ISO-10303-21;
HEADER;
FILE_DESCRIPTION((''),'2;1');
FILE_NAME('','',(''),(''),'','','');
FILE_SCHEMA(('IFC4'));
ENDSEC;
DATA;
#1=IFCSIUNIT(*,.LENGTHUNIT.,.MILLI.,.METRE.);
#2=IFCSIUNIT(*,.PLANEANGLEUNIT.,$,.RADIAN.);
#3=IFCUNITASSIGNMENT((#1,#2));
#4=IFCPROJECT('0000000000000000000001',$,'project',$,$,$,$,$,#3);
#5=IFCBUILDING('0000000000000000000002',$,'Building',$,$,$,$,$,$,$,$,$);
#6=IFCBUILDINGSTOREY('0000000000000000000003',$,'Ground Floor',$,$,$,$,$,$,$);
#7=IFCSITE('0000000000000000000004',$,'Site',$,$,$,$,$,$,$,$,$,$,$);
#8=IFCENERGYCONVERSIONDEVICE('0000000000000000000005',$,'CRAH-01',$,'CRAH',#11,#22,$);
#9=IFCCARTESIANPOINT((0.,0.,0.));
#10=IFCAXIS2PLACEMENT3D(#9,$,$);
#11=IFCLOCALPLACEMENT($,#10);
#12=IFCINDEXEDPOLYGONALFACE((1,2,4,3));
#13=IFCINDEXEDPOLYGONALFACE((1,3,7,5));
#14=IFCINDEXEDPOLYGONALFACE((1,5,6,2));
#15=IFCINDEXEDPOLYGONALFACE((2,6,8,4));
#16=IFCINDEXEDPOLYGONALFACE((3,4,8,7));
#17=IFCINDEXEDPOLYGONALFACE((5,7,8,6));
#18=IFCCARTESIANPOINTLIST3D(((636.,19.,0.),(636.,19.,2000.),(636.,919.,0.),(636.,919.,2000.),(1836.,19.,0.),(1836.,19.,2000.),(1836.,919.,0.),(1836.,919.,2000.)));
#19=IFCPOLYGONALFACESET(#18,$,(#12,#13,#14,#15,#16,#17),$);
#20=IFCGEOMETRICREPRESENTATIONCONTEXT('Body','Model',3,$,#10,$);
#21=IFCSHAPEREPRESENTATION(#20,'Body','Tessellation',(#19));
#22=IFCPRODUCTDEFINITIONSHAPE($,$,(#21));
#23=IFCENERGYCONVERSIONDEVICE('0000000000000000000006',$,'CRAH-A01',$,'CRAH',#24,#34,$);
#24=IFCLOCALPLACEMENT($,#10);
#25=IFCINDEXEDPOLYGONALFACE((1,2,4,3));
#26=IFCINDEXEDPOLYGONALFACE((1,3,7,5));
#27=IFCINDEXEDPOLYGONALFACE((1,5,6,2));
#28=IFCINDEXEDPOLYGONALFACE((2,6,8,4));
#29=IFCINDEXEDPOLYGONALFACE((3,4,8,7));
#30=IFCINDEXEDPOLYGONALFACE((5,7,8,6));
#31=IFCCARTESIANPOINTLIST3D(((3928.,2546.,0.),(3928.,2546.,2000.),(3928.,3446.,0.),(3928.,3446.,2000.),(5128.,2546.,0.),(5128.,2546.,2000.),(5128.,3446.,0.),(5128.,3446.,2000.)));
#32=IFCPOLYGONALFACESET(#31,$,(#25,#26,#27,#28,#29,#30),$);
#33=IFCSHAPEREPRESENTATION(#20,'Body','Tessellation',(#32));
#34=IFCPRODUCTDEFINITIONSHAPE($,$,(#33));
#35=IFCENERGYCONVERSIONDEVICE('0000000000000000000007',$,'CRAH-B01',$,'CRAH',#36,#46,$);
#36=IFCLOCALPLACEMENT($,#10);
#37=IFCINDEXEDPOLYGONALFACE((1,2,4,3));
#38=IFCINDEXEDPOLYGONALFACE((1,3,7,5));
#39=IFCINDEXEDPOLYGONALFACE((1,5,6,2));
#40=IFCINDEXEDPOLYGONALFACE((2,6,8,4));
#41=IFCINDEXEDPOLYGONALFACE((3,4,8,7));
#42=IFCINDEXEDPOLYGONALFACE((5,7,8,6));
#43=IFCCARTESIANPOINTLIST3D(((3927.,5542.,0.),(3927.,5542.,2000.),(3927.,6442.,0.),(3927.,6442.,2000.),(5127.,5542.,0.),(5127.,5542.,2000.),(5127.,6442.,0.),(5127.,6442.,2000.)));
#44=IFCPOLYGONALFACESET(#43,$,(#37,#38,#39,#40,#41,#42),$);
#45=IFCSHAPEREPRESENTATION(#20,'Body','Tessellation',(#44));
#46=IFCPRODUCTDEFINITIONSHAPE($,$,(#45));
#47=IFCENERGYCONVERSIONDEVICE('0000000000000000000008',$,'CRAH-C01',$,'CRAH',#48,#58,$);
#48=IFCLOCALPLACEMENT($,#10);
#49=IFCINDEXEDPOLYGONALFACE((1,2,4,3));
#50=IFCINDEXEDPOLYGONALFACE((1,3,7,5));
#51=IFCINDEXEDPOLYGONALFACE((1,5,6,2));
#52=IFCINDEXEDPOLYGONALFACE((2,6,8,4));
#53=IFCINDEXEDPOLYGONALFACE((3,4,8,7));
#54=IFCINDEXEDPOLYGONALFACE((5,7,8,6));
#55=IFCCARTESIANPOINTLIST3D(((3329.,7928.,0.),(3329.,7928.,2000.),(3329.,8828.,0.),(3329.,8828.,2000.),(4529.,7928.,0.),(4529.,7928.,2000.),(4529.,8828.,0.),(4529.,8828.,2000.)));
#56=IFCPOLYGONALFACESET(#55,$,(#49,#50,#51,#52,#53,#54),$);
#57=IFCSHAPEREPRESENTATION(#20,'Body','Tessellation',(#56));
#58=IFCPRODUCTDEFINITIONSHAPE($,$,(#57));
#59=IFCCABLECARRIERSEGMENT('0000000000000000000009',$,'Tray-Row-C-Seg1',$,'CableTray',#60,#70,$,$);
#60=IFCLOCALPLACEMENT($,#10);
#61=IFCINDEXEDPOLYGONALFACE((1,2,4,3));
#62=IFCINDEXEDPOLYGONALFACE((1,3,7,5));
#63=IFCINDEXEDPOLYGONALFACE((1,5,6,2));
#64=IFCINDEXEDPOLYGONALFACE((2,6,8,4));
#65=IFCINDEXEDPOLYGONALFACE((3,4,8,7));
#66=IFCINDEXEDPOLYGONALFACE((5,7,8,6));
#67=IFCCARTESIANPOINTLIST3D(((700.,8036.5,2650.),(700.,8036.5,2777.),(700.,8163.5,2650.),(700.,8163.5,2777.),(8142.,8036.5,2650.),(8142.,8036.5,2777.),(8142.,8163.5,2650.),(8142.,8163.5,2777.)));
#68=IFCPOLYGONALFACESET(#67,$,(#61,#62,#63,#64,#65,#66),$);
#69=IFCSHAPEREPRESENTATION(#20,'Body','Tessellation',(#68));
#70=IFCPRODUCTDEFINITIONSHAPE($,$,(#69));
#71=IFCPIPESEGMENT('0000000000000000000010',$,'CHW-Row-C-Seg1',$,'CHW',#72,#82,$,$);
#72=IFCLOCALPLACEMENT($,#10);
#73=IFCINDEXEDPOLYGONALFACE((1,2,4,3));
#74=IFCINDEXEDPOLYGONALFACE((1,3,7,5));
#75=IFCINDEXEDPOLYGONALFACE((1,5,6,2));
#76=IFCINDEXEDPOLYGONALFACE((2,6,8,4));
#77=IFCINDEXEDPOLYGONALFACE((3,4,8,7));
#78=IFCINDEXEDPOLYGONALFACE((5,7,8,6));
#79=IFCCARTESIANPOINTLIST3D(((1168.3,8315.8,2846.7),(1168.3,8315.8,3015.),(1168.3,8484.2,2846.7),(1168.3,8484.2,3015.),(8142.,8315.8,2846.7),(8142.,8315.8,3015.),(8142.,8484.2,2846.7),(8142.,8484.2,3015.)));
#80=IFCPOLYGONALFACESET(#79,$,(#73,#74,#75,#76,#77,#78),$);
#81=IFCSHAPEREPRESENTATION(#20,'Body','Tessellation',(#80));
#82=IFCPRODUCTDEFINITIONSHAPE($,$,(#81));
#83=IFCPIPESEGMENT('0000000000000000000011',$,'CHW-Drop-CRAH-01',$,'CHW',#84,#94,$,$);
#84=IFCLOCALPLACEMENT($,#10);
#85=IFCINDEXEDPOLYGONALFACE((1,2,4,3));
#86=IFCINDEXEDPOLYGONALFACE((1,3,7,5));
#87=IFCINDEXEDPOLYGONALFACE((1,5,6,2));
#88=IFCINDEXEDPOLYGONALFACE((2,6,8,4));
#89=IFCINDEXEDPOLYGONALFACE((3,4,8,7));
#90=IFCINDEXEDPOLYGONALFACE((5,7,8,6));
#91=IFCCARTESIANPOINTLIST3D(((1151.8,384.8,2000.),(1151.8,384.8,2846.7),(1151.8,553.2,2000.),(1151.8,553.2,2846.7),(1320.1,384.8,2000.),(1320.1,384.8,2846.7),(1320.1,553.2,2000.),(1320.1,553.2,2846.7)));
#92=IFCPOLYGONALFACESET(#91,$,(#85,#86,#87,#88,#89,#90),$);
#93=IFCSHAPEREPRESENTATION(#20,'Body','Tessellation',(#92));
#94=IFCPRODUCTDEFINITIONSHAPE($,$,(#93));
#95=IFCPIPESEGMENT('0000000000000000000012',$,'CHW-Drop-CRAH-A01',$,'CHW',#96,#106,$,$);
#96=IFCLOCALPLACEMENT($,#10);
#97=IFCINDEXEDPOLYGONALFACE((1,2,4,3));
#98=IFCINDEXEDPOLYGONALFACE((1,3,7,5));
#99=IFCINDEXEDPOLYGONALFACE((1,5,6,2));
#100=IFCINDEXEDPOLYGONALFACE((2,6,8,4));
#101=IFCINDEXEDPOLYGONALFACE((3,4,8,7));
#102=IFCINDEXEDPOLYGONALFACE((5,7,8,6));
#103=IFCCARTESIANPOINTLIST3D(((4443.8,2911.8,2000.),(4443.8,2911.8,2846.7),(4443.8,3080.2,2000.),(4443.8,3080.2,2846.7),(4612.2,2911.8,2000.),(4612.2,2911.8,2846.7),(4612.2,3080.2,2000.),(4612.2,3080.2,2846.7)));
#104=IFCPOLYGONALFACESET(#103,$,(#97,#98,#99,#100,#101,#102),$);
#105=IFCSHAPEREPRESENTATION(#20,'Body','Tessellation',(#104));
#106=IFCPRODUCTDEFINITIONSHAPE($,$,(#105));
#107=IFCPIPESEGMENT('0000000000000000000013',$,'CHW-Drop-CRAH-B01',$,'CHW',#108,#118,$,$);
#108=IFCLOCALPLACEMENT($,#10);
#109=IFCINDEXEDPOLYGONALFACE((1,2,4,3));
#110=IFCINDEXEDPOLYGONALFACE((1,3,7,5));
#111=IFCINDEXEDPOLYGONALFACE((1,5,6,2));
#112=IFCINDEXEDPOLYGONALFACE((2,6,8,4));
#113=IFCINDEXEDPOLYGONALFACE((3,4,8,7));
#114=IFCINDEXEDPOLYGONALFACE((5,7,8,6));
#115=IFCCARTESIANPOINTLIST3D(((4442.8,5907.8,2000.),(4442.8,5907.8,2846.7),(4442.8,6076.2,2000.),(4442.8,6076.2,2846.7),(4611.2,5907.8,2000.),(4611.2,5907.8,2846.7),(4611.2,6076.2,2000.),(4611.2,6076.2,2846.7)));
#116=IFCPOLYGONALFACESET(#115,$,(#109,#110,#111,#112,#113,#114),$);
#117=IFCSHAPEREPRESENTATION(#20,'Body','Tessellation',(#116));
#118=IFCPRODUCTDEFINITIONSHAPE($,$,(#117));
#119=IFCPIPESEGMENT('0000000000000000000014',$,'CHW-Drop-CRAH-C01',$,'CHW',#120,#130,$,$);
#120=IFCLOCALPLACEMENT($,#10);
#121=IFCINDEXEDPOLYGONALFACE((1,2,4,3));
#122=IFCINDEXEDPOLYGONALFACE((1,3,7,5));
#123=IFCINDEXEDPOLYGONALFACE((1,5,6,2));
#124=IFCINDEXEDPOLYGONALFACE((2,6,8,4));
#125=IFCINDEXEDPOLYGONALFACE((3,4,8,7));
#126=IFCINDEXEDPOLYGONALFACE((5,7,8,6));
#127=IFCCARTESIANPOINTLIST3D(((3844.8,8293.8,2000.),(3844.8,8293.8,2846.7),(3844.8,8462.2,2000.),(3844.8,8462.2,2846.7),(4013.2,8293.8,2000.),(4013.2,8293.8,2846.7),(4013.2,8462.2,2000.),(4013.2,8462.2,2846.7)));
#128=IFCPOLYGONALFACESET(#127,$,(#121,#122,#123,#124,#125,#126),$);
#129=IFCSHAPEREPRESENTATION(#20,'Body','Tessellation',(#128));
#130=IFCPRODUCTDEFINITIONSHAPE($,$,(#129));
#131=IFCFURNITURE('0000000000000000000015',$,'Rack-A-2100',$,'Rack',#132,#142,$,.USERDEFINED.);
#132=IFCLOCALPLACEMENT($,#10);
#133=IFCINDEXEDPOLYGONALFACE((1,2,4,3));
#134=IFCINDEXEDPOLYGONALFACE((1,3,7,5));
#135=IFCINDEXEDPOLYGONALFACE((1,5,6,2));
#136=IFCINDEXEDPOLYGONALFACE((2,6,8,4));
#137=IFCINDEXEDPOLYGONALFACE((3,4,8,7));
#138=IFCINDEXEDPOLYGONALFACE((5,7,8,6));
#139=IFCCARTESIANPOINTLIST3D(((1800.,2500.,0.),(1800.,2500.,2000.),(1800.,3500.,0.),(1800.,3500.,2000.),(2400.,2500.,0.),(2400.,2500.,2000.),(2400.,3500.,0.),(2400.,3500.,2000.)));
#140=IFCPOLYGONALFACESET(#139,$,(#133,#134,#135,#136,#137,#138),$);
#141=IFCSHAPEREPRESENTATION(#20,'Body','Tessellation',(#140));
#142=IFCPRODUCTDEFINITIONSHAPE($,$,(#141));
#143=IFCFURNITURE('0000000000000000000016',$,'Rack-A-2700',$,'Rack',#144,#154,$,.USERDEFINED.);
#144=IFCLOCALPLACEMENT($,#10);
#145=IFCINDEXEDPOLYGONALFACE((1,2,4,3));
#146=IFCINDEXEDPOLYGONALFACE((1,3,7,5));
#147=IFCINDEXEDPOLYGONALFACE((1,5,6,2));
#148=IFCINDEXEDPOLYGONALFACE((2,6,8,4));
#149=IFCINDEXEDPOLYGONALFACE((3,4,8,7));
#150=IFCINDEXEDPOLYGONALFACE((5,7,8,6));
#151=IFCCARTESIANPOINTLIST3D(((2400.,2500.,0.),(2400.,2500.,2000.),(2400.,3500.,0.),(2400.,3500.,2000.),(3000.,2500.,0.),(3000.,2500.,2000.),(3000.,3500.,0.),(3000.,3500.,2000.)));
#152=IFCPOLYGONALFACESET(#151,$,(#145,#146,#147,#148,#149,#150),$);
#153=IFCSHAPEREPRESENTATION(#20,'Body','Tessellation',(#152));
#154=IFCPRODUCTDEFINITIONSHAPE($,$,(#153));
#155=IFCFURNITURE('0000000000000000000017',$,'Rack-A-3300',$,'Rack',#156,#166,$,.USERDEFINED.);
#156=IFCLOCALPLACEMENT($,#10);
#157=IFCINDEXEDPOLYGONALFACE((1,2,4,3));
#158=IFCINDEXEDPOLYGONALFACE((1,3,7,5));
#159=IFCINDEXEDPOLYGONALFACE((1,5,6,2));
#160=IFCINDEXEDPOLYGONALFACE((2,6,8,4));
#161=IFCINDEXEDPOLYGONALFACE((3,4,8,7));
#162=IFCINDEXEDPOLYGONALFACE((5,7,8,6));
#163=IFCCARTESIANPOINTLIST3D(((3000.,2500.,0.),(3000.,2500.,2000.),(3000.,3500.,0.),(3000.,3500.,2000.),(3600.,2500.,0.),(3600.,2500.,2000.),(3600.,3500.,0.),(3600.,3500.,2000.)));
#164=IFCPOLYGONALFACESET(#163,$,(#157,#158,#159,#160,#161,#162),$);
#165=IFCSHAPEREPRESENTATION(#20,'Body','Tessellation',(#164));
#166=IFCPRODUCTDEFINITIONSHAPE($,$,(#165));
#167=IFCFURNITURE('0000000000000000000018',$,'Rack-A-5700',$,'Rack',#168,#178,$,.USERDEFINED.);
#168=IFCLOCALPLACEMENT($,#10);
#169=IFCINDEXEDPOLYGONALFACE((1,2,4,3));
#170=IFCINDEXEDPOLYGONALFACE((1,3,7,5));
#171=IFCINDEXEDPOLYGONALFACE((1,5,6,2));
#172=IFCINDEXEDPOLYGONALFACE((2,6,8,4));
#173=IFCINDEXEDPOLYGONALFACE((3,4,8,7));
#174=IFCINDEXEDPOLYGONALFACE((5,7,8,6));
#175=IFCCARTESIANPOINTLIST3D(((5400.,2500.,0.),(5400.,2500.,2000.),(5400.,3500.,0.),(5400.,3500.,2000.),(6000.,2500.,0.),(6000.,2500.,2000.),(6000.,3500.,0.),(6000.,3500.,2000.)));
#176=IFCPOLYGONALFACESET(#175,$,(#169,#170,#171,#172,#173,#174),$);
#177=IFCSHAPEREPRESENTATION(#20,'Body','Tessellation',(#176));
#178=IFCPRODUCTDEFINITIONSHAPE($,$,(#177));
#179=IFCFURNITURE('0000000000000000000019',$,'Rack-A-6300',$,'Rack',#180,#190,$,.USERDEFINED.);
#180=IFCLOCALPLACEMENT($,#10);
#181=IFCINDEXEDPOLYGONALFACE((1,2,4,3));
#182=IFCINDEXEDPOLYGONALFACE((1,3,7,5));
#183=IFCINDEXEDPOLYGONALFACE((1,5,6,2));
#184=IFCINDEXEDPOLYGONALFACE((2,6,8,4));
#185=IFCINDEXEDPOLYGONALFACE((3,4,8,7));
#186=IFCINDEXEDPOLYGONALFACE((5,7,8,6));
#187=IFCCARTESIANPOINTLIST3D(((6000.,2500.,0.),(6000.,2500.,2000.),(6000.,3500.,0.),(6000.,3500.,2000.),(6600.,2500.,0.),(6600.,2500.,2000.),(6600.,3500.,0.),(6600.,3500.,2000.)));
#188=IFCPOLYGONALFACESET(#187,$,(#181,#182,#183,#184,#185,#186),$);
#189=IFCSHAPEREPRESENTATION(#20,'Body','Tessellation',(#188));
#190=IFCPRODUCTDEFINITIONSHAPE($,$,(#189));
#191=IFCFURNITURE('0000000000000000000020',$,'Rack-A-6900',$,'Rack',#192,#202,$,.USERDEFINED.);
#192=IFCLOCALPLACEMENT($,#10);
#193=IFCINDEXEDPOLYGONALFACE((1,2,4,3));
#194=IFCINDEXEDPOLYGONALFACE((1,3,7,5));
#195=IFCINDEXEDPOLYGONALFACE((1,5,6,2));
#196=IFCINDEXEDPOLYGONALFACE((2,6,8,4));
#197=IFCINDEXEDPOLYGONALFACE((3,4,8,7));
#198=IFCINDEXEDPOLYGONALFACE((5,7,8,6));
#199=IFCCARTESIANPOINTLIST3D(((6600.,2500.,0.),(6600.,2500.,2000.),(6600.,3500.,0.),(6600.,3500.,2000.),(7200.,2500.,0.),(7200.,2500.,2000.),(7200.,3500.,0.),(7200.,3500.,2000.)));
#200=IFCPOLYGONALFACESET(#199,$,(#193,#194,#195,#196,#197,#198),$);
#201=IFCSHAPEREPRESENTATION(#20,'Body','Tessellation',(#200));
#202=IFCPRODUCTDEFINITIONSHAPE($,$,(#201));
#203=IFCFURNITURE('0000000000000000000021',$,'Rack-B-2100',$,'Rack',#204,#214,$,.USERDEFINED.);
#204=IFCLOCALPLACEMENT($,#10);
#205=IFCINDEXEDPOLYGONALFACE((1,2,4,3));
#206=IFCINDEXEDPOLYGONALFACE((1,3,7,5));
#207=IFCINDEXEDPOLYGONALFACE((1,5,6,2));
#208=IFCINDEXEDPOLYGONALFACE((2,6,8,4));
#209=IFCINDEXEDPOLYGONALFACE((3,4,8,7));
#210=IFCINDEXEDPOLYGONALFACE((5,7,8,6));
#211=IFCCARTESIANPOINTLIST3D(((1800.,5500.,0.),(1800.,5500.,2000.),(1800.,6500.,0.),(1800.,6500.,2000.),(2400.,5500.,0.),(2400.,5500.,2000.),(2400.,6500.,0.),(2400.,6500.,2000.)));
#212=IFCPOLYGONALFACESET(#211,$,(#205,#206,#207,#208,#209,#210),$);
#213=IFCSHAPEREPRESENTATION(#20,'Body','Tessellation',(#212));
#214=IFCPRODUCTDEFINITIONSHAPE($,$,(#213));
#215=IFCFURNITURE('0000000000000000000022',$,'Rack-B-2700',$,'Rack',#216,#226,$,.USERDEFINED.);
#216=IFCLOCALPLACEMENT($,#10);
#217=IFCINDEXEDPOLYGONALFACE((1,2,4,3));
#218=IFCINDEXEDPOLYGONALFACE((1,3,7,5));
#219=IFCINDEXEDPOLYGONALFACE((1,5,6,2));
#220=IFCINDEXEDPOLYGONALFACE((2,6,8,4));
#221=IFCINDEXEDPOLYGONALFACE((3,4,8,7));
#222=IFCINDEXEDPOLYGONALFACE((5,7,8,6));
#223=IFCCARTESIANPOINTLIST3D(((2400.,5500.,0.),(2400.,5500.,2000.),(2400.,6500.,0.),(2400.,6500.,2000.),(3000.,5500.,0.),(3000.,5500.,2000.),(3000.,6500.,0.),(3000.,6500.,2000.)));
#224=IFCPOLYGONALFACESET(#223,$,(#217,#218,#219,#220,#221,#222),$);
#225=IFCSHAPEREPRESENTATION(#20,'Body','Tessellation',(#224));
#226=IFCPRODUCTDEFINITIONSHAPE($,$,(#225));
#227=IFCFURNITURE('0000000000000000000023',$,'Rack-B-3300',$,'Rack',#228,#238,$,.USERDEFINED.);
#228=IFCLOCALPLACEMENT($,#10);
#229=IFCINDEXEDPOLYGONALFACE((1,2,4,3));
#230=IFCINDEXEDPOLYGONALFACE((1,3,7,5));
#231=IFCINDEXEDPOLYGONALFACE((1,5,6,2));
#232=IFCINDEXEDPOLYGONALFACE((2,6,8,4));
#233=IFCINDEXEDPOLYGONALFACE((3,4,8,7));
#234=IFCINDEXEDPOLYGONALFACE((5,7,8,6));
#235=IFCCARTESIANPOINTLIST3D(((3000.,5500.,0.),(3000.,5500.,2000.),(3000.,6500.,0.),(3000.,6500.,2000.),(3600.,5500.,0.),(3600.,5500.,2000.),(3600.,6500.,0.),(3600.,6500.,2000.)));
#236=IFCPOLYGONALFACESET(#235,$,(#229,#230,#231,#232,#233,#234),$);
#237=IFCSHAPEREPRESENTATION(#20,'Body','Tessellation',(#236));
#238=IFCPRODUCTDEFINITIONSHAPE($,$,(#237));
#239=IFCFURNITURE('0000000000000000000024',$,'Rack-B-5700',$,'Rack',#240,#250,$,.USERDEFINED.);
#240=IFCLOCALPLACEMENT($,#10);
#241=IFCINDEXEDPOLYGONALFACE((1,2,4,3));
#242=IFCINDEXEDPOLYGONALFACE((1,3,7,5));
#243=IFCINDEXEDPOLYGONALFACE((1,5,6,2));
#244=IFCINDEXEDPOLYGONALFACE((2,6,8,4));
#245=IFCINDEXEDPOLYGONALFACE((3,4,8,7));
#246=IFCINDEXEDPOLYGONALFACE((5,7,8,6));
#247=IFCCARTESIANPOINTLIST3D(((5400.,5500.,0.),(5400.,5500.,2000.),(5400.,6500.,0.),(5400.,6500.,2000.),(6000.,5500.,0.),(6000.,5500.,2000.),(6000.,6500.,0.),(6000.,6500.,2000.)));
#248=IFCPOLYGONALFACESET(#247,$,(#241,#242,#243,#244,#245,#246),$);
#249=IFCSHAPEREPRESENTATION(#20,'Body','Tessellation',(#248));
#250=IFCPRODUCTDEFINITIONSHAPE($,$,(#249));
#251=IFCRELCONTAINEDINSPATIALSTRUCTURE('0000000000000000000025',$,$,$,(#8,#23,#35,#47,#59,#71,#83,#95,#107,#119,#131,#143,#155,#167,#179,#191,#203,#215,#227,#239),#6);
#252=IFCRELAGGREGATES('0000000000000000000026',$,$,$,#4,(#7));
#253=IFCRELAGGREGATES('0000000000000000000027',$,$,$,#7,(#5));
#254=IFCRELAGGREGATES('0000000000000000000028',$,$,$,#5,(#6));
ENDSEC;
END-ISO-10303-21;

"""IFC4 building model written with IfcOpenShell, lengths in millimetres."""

from ifc_helpers import new_model, si_unit, frame, origin, place, context, project, spatial, rectangle, extrude, element, save


model = new_model("IFC4")

# Units and contexts
model_context = context("Model", 3, world=origin(), identifier="Body")
ifc_project = project(units=[si_unit("LENGTHUNIT", "METRE", prefix="MILLI"), si_unit("PLANEANGLEUNIT", "RADIAN")])

# Site, building, storey
site = spatial("IfcSite", under=ifc_project, Name="Site")
building = spatial("IfcBuilding", under=site, Name="Building")
storey = spatial("IfcBuildingStorey", under=building, Name="Ground Floor")

# Energy conversion devices
for number, where, z_axis, x_axis, name in (
    (1, (1236.0, 469.0, 0.0), (0.0, 0.0, 1.0), (1.0, 0.0, 0.0), "CRAH-01"),
    (2, (4528.0, 2996.0, 0.0), (0.0, 0.0, 1.0), (1.0, 0.0, 0.0), "CRAH-A01"),
    (3, (4527.0, 5992.0, 0.0), (0.0, 0.0, 1.0), (1.0, 0.0, 0.0), "CRAH-B01"),
    (4, (3929.0, 8378.0, 0.0), (0.0, 0.0, 1.0), (1.0, 0.0, 0.0), "CRAH-C01"),
):
    element("IfcEnergyConversionDevice", number, at=place(None, frame(where, z_axis=z_axis, x_axis=x_axis)), inside=storey, Name=name, ObjectType="CRAH", context=model_context, shape_type="SweptSolid", body=[
        extrude(rectangle(XDim=1200.0, YDim=900.0), origin(), (0.0, 0.0, 1.0), 2000.0),
    ])

# Cable carrier segment
cable_carrier_segment_placement = place(None, frame((4421.0, 8100.0, 2650.0), z_axis=(0.0, 0.0, 1.0), x_axis=(1.0, 0.0, 0.0)))
element("IfcCableCarrierSegment", 5, at=cable_carrier_segment_placement, inside=storey, Name="Tray-Row-C-Seg1", ObjectType="CableTray", context=model_context, shape_type="SweptSolid", body=[
    extrude(rectangle(XDim=7442.0, YDim=127.0), origin(), (0.0, 0.0, 1.0), 127.0),
])

# Pipe segments
pipe_segment_placement = place(None, frame((4655.1, 8400.0, 2846.7), z_axis=(0.0, 0.0, 1.0), x_axis=(1.0, 0.0, 0.0)))
element("IfcPipeSegment", 6, at=pipe_segment_placement, inside=storey, Name="CHW-Row-C-Seg1", ObjectType="CHW", context=model_context, shape_type="SweptSolid", body=[
    extrude(rectangle(XDim=6973.7, YDim=168.3), origin(), (0.0, 0.0, 1.0), 168.3),
])
for number, where, z_axis, x_axis, name in (
    (7, (1236.0, 469.0, 2000.0), (0.0, 0.0, 1.0), (1.0, 0.0, 0.0), "CHW-Drop-CRAH-01"),
    (8, (4528.0, 2996.0, 2000.0), (0.0, 0.0, 1.0), (1.0, 0.0, 0.0), "CHW-Drop-CRAH-A01"),
    (9, (4527.0, 5992.0, 2000.0), (0.0, 0.0, 1.0), (1.0, 0.0, 0.0), "CHW-Drop-CRAH-B01"),
    (10, (3929.0, 8378.0, 2000.0), (0.0, 0.0, 1.0), (1.0, 0.0, 0.0), "CHW-Drop-CRAH-C01"),
):
    element("IfcPipeSegment", number, at=place(None, frame(where, z_axis=z_axis, x_axis=x_axis)), inside=storey, Name=name, ObjectType="CHW", context=model_context, shape_type="SweptSolid", body=[
        extrude(rectangle(XDim=168.3, YDim=168.3), origin(), (0.0, 0.0, 1.0), 846.7),
    ])

# Furniture
for number, where, z_axis, x_axis, name in (
    (11, (2100.0, 3000.0, 0.0), (0.0, 0.0, 1.0), (1.0, 0.0, 0.0), "Rack-A-2100"),
    (12, (2700.0, 3000.0, 0.0), (0.0, 0.0, 1.0), (1.0, 0.0, 0.0), "Rack-A-2700"),
    (13, (3300.0, 3000.0, 0.0), (0.0, 0.0, 1.0), (1.0, 0.0, 0.0), "Rack-A-3300"),
    (14, (5700.0, 3000.0, 0.0), (0.0, 0.0, 1.0), (1.0, 0.0, 0.0), "Rack-A-5700"),
    (15, (6300.0, 3000.0, 0.0), (0.0, 0.0, 1.0), (1.0, 0.0, 0.0), "Rack-A-6300"),
    (16, (6900.0, 3000.0, 0.0), (0.0, 0.0, 1.0), (1.0, 0.0, 0.0), "Rack-A-6900"),
    (17, (2100.0, 6000.0, 0.0), (0.0, 0.0, 1.0), (1.0, 0.0, 0.0), "Rack-B-2100"),
    (18, (2700.0, 6000.0, 0.0), (0.0, 0.0, 1.0), (1.0, 0.0, 0.0), "Rack-B-2700"),
    (19, (3300.0, 6000.0, 0.0), (0.0, 0.0, 1.0), (1.0, 0.0, 0.0), "Rack-B-3300"),
    (20, (5700.0, 6000.0, 0.0), (0.0, 0.0, 1.0), (1.0, 0.0, 0.0), "Rack-B-5700"),
):
    element("IfcFurniture", number, at=place(None, frame(where, z_axis=z_axis, x_axis=x_axis)), inside=storey, Name=name, ObjectType="Rack", PredefinedType="USERDEFINED", context=model_context, shape_type="SweptSolid", body=[
        extrude(rectangle(XDim=600.0, YDim=1000.0), origin(), (0.0, 0.0, 1.0), 2000.0),
    ])

save(model, "model.ifc")
